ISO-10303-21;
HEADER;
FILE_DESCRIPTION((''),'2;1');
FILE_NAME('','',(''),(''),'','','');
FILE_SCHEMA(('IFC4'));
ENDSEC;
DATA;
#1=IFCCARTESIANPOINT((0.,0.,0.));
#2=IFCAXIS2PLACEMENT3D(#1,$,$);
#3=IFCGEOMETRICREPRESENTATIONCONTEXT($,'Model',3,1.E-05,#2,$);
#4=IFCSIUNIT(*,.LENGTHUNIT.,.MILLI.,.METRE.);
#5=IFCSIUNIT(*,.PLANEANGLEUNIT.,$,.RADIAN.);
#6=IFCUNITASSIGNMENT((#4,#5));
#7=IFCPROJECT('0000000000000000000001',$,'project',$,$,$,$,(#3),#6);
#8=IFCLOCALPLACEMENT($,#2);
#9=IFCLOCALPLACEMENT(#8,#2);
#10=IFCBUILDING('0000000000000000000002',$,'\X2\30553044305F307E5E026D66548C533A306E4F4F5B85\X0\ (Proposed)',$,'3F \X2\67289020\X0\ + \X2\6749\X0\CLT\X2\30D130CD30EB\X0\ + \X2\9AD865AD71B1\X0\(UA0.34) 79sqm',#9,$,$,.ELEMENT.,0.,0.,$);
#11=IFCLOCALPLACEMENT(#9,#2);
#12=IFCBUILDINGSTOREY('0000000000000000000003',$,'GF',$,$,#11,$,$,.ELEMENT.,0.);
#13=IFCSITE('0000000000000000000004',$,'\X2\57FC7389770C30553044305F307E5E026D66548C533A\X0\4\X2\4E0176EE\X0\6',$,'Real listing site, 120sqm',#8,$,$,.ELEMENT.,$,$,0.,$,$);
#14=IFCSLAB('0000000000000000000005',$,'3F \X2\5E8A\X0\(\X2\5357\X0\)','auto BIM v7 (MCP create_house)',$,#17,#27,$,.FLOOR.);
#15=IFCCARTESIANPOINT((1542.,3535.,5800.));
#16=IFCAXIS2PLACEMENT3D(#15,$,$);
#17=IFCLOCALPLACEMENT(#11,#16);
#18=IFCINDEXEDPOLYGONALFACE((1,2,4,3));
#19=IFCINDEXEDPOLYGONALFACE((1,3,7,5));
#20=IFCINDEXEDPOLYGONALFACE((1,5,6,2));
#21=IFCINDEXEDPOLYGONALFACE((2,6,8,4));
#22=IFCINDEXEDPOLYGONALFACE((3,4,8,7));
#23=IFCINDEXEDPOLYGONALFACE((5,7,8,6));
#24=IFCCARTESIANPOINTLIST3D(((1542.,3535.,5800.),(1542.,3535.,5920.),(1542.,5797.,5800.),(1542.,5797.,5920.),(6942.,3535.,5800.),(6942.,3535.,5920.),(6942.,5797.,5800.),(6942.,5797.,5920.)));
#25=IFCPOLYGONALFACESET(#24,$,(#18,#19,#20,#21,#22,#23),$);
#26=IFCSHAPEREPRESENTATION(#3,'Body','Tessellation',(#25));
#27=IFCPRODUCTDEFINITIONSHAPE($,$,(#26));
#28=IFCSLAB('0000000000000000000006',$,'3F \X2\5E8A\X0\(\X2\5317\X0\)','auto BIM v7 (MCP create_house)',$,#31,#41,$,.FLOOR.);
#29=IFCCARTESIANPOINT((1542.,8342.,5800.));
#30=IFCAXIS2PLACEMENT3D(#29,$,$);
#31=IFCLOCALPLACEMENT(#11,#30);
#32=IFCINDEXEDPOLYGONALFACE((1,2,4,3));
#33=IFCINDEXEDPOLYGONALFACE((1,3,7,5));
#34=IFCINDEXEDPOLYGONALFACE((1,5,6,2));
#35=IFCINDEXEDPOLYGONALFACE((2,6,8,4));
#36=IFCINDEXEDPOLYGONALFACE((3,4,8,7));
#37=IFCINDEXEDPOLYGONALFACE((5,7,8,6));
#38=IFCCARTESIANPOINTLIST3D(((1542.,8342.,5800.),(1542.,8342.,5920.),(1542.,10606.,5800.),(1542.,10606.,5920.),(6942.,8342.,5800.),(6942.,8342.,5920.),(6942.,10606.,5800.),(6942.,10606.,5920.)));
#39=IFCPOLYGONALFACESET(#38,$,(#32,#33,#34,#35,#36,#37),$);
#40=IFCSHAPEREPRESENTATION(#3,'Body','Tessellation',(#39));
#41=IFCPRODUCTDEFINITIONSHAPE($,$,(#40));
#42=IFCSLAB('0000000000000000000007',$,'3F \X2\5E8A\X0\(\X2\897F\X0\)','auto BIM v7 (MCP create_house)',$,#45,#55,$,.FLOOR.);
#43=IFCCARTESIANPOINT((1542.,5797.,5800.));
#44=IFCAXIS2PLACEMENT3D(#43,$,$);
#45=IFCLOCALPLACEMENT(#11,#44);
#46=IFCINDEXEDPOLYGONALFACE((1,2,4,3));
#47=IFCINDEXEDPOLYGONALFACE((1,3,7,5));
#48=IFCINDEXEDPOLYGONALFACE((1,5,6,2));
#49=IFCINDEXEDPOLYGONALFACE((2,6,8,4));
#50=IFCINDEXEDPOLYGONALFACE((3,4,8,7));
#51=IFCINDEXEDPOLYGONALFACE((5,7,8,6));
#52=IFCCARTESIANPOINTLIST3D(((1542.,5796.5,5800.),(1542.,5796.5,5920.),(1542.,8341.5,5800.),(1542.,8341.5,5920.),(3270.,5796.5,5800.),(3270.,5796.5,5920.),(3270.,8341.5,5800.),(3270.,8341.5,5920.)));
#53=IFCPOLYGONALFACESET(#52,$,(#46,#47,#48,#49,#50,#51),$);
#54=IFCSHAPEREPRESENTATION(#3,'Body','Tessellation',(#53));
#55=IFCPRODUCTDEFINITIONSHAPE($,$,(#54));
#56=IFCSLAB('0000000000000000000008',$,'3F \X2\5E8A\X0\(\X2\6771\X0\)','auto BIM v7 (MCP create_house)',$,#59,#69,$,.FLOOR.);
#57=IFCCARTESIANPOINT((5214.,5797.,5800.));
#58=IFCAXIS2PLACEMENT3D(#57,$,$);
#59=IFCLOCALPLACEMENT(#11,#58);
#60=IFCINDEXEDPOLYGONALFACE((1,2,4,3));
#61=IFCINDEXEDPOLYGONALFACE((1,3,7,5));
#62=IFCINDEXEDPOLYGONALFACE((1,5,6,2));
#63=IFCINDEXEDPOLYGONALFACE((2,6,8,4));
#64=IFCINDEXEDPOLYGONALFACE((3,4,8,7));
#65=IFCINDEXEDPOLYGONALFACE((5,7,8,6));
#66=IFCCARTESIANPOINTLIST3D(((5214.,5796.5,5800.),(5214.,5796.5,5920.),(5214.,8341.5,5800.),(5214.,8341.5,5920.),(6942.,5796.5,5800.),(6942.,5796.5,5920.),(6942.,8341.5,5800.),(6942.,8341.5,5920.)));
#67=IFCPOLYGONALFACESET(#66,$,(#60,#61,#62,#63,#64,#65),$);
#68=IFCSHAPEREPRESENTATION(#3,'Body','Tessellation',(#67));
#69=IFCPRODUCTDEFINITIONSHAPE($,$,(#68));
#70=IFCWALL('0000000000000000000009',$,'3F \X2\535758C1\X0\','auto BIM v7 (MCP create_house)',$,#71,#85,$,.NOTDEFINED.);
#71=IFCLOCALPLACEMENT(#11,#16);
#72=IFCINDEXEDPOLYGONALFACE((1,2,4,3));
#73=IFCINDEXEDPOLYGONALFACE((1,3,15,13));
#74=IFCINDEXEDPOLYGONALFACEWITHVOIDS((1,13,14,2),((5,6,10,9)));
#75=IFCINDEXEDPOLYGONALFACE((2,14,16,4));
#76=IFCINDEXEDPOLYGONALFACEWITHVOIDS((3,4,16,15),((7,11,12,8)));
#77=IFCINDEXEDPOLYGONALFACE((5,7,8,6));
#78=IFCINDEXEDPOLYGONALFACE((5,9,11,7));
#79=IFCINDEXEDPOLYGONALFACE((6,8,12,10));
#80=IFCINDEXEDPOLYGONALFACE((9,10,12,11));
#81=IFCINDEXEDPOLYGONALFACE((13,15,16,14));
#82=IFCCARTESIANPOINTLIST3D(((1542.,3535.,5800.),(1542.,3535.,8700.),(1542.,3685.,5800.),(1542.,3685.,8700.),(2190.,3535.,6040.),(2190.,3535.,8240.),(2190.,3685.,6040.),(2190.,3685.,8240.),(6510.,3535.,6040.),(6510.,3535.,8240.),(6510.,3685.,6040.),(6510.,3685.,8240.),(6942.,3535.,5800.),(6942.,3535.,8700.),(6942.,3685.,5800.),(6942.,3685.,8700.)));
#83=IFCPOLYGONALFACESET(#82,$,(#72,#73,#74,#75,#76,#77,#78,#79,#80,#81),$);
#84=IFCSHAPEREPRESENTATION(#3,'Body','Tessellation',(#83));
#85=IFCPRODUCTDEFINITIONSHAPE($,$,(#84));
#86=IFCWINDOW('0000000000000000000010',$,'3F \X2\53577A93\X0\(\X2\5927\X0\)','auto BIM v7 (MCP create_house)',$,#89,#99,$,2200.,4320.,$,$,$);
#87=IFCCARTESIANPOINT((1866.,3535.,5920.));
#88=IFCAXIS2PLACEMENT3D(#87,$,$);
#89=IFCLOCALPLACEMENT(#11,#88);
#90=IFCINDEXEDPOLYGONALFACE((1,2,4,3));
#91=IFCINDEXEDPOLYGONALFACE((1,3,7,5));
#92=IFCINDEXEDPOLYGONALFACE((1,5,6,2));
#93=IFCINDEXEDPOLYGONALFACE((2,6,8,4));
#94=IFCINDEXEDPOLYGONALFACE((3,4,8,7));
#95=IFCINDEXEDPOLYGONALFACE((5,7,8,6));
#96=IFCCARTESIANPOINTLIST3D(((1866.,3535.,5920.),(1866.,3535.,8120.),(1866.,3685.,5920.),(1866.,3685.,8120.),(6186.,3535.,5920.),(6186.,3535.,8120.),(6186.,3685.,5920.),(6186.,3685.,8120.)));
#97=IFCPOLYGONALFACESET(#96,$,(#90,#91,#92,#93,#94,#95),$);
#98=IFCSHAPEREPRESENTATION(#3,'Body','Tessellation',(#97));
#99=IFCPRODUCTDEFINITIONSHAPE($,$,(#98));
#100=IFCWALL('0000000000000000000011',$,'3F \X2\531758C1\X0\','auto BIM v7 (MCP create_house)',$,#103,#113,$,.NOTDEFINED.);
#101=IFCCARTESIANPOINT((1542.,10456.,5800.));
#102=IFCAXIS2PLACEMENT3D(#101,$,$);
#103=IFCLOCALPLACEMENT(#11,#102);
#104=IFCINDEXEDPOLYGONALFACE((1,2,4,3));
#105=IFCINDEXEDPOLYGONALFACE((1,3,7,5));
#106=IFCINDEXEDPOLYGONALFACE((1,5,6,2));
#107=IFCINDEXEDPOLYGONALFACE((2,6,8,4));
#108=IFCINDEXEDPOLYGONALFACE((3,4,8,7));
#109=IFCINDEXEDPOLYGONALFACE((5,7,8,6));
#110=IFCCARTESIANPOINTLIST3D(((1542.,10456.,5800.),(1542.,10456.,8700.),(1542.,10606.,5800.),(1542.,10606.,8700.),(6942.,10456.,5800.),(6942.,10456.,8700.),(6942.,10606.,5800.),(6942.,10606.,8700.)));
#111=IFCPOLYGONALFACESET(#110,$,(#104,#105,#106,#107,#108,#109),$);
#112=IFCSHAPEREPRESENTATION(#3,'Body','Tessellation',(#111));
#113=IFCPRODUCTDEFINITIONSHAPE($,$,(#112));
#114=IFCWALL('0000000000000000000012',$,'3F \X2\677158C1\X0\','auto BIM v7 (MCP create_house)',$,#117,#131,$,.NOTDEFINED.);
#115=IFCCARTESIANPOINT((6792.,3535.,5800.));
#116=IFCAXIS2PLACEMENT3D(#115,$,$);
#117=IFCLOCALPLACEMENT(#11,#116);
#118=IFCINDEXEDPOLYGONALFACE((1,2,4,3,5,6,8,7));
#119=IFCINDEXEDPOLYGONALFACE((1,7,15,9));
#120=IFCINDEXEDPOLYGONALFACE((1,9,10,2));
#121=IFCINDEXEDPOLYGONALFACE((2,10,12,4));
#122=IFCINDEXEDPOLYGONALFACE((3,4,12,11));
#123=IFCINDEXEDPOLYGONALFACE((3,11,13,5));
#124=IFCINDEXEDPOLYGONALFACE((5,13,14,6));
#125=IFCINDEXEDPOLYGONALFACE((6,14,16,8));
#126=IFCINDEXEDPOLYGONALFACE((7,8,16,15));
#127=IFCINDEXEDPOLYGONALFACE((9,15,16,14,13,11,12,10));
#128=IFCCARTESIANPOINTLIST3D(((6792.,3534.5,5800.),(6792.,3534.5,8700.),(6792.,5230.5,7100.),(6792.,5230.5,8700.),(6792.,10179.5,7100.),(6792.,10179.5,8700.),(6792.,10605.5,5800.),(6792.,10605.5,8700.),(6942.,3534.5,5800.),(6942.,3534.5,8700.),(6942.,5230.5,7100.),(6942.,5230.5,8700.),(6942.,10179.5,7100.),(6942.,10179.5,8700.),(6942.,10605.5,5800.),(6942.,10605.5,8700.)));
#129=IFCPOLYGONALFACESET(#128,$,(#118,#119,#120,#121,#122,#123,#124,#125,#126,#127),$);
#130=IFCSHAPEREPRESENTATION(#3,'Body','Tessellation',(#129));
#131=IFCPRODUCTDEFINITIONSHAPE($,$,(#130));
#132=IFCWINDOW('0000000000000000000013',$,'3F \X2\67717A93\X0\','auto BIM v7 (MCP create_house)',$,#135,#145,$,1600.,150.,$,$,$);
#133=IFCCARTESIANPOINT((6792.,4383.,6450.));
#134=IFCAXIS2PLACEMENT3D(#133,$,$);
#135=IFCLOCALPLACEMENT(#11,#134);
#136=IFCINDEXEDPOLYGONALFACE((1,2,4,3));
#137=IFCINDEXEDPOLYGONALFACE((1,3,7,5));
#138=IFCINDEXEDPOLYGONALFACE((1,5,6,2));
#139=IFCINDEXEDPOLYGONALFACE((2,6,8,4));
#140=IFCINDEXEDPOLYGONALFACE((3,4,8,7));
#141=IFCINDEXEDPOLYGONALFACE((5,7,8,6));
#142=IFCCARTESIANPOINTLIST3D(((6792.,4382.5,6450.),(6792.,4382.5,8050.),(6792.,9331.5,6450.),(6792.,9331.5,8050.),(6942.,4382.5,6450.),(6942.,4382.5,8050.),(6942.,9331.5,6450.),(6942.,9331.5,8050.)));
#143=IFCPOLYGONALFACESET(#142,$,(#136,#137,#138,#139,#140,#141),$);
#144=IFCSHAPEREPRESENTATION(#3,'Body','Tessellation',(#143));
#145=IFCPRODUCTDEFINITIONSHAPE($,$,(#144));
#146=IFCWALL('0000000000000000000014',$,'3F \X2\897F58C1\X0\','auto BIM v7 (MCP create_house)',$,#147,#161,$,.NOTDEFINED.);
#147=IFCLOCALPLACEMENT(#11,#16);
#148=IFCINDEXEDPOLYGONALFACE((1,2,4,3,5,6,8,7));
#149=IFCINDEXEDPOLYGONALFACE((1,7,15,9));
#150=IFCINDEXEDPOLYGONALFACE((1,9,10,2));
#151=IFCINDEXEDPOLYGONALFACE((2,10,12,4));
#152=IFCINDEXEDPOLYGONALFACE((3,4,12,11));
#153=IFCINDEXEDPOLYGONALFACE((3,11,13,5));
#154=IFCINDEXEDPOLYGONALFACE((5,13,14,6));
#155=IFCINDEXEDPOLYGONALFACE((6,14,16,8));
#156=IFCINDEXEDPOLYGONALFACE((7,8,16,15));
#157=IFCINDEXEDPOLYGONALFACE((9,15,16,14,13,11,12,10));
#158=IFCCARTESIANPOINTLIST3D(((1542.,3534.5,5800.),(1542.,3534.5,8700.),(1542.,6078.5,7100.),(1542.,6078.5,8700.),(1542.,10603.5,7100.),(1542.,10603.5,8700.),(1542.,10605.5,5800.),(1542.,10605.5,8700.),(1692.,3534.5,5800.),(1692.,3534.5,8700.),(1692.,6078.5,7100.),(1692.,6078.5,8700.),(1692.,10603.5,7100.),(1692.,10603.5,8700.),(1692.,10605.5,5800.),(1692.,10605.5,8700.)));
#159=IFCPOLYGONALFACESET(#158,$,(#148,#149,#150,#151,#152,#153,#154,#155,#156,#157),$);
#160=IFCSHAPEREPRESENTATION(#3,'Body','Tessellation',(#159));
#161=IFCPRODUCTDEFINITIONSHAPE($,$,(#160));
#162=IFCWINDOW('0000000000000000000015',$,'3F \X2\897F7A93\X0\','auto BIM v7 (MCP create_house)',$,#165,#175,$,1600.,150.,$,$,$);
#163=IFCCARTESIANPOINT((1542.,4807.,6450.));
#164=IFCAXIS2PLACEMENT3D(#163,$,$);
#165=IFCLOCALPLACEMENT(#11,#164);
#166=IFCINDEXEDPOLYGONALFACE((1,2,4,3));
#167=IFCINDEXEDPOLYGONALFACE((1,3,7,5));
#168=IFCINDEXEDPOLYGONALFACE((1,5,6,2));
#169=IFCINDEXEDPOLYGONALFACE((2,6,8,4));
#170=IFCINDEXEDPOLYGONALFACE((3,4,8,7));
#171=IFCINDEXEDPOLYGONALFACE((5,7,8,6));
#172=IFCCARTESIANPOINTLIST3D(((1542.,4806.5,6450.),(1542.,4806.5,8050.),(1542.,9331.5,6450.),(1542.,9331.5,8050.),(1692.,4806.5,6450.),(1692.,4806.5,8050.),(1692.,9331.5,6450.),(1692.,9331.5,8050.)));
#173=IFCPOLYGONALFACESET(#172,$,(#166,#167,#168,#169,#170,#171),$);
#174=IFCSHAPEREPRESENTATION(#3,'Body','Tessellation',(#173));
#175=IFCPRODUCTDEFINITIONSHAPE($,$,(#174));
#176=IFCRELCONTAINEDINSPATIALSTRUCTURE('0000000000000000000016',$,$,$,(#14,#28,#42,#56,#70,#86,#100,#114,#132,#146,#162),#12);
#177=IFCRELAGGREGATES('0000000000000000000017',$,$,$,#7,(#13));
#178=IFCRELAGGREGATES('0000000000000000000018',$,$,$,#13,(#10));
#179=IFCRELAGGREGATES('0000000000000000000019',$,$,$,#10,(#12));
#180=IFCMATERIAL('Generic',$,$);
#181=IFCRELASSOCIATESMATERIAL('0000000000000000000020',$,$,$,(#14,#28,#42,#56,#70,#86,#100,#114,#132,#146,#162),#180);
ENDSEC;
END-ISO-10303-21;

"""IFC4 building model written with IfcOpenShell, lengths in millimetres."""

from ifc_helpers import new_model, si_unit, frame, frame_2d, origin, place, context, project, spatial, rectangle, extrude, material, element, fill, save


model = new_model("IFC4")

# Units and contexts
model_context = context("Model", 3, precision=1e-05, world=origin())
ifc_project = project(units=[si_unit("LENGTHUNIT", "METRE", prefix="MILLI"), si_unit("PLANEANGLEUNIT", "RADIAN")], contexts=[model_context])

# Site, building, storey
site_placement = place(None, origin())
site = spatial("IfcSite", under=ifc_project, at=site_placement, Name="埼玉県さいたま市浦和区4丁目6", ObjectType="Real listing site, 120sqm", CompositionType="ELEMENT", RefElevation=0.0)
building_placement = place(site_placement, origin())
building = spatial("IfcBuilding", under=site, at=building_placement, Name="さいたま市浦和区の住宅 (Proposed)", ObjectType="3F 木造 + 杉CLTパネル + 高断熱(UA0.34) 79sqm", CompositionType="ELEMENT", ElevationOfRefHeight=0.0, ElevationOfTerrain=0.0)
storey_placement = place(building_placement, origin())
storey = spatial("IfcBuildingStorey", under=building, at=storey_placement, Name="GF", CompositionType="ELEMENT", Elevation=0.0)

# Slabs
ifc_material = material(Name="Generic")
slab_1_placement = place(storey_placement, frame((1542.0, 3535.0, 5800.0)))
element("IfcSlab", 1, at=slab_1_placement, inside=storey, material=ifc_material, Name="3F 床(南)", Description="auto BIM v7 (MCP create_house)", PredefinedType="FLOOR", context=model_context, shape_type="SweptSolid", body=[
    extrude(rectangle(XDim=5400.0, YDim=2262.0, at=frame_2d((2700.0, 1131.0))), frame((1542.0, 3535.0, 5800.0)), (0.0, 0.0, 1.0), 120.0),
])
slab_2_placement = place(storey_placement, frame((1542.0, 8342.0, 5800.0)))
element("IfcSlab", 2, at=slab_2_placement, inside=storey, material=ifc_material, Name="3F 床(北)", Description="auto BIM v7 (MCP create_house)", PredefinedType="FLOOR", context=model_context, shape_type="SweptSolid", body=[
    extrude(rectangle(XDim=5400.0, YDim=2264.0, at=frame_2d((2700.0, 1132.0))), frame((1542.0, 8342.0, 5800.0)), (0.0, 0.0, 1.0), 120.0),
])
slab_3_placement = place(storey_placement, frame((1542.0, 5797.0, 5800.0)))
element("IfcSlab", 3, at=slab_3_placement, inside=storey, material=ifc_material, Name="3F 床(西)", Description="auto BIM v7 (MCP create_house)", PredefinedType="FLOOR", context=model_context, shape_type="SweptSolid", body=[
    extrude(rectangle(XDim=1728.0, YDim=2545.0, at=frame_2d((864.0, 1272.0))), frame((1542.0, 5797.0, 5800.0)), (0.0, 0.0, 1.0), 120.0),
])
slab_4_placement = place(storey_placement, frame((5214.0, 5797.0, 5800.0)))
element("IfcSlab", 4, at=slab_4_placement, inside=storey, material=ifc_material, Name="3F 床(東)", Description="auto BIM v7 (MCP create_house)", PredefinedType="FLOOR", context=model_context, shape_type="SweptSolid", body=[
    extrude(rectangle(XDim=1728.0, YDim=2545.0, at=frame_2d((864.0, 1272.0))), frame((5214.0, 5797.0, 5800.0)), (0.0, 0.0, 1.0), 120.0),
])

# Wall, opening, window
wall_1_placement = place(storey_placement, frame((1542.0, 3535.0, 5800.0)))
wall_1 = element("IfcWall", 5, at=wall_1_placement, inside=storey, material=ifc_material, Name="3F 南壁", Description="auto BIM v7 (MCP create_house)", PredefinedType="NOTDEFINED", context=model_context, shape_type="SweptSolid", body=[
    extrude(rectangle(XDim=5400.0, YDim=150.0, at=frame_2d((2700.0, 75.0))), frame((1542.0, 3535.0, 5800.0)), (0.0, 0.0, 1.0), 2900.0),
])
opening_1_placement = place(storey_placement, frame((1866.0, 3535.0, 5920.0)))
opening_1 = element("IfcOpeningElement", 6, at=opening_1_placement, cuts=wall_1, PredefinedType="NOTDEFINED", context=model_context, shape_type="SweptSolid", body=[
    extrude(rectangle(XDim=4320.0, YDim=150.0, at=frame_2d((2160.0, 75.0))), frame((1866.0, 3535.0, 5920.0)), (0.0, 0.0, 1.0), 2200.0),
])
window_1_placement = place(storey_placement, frame((1866.0, 3535.0, 5920.0)))
window_1 = element("IfcWindow", 7, at=window_1_placement, inside=storey, material=ifc_material, Name="3F 南窓(大)", Description="auto BIM v7 (MCP create_house)", OverallHeight=2200.0, OverallWidth=4320.0, context=model_context, shape_type="SweptSolid", body=[
    extrude(rectangle(XDim=4320.0, YDim=150.0, at=frame_2d((2160.0, 75.0))), frame((1866.0, 3535.0, 5920.0)), (0.0, 0.0, 1.0), 2200.0),
])
fill(opening_1, window_1)

# Wall
wall_2_placement = place(storey_placement, frame((1542.0, 10456.0, 5800.0)))
element("IfcWall", 8, at=wall_2_placement, inside=storey, material=ifc_material, Name="3F 北壁", Description="auto BIM v7 (MCP create_house)", PredefinedType="NOTDEFINED", context=model_context, shape_type="SweptSolid", body=[
    extrude(rectangle(XDim=5400.0, YDim=150.0, at=frame_2d((2700.0, 75.0))), frame((1542.0, 10456.0, 5800.0)), (0.0, 0.0, 1.0), 2900.0),
])

# Walls, openings, windows
wall_3_placement = place(storey_placement, frame((6792.0, 3535.0, 5800.0)))
wall_3 = element("IfcWall", 9, at=wall_3_placement, inside=storey, material=ifc_material, Name="3F 東壁", Description="auto BIM v7 (MCP create_house)", PredefinedType="NOTDEFINED", context=model_context, shape_type="SweptSolid", body=[
    extrude(rectangle(XDim=150.0, YDim=7071.0, at=frame_2d((75.0, 3535.0))), frame((6792.0, 3535.0, 5800.0)), (0.0, 0.0, 1.0), 2900.0),
])
opening_2_placement = place(storey_placement, frame((6792.0, 4383.0, 6450.0)))
opening_2 = element("IfcOpeningElement", 10, at=opening_2_placement, cuts=wall_3, PredefinedType="NOTDEFINED", context=model_context, shape_type="SweptSolid", body=[
    extrude(rectangle(XDim=150.0, YDim=4949.0, at=frame_2d((75.0, 2474.0))), frame((6792.0, 4383.0, 6450.0)), (0.0, 0.0, 1.0), 1600.0),
])
window_2_placement = place(storey_placement, frame((6792.0, 4383.0, 6450.0)))
window_2 = element("IfcWindow", 11, at=window_2_placement, inside=storey, material=ifc_material, Name="3F 東窓", Description="auto BIM v7 (MCP create_house)", OverallHeight=1600.0, OverallWidth=150.0, context=model_context, shape_type="SweptSolid", body=[
    extrude(rectangle(XDim=150.0, YDim=4949.0, at=frame_2d((75.0, 2474.0))), frame((6792.0, 4383.0, 6450.0)), (0.0, 0.0, 1.0), 1600.0),
])
fill(opening_2, window_2)
wall_4_placement = place(storey_placement, frame((1542.0, 3535.0, 5800.0)))
wall_4 = element("IfcWall", 12, at=wall_4_placement, inside=storey, material=ifc_material, Name="3F 西壁", Description="auto BIM v7 (MCP create_house)", PredefinedType="NOTDEFINED", context=model_context, shape_type="SweptSolid", body=[
    extrude(rectangle(XDim=150.0, YDim=7071.0, at=frame_2d((75.0, 3535.0))), frame((1542.0, 3535.0, 5800.0)), (0.0, 0.0, 1.0), 2900.0),
])
opening_3_placement = place(storey_placement, frame((1542.0, 4807.0, 6450.0)))
opening_3 = element("IfcOpeningElement", 13, at=opening_3_placement, cuts=wall_4, PredefinedType="NOTDEFINED", context=model_context, shape_type="SweptSolid", body=[
    extrude(rectangle(XDim=150.0, YDim=4525.0, at=frame_2d((75.0, 2262.0))), frame((1542.0, 4807.0, 6450.0)), (0.0, 0.0, 1.0), 1600.0),
])
window_3_placement = place(storey_placement, frame((1542.0, 4807.0, 6450.0)))
window_3 = element("IfcWindow", 14, at=window_3_placement, inside=storey, material=ifc_material, Name="3F 西窓", Description="auto BIM v7 (MCP create_house)", OverallHeight=1600.0, OverallWidth=150.0, context=model_context, shape_type="SweptSolid", body=[
    extrude(rectangle(XDim=150.0, YDim=4525.0, at=frame_2d((75.0, 2262.0))), frame((1542.0, 4807.0, 6450.0)), (0.0, 0.0, 1.0), 1600.0),
])
fill(opening_3, window_3)

save(model, "model.ifc")
